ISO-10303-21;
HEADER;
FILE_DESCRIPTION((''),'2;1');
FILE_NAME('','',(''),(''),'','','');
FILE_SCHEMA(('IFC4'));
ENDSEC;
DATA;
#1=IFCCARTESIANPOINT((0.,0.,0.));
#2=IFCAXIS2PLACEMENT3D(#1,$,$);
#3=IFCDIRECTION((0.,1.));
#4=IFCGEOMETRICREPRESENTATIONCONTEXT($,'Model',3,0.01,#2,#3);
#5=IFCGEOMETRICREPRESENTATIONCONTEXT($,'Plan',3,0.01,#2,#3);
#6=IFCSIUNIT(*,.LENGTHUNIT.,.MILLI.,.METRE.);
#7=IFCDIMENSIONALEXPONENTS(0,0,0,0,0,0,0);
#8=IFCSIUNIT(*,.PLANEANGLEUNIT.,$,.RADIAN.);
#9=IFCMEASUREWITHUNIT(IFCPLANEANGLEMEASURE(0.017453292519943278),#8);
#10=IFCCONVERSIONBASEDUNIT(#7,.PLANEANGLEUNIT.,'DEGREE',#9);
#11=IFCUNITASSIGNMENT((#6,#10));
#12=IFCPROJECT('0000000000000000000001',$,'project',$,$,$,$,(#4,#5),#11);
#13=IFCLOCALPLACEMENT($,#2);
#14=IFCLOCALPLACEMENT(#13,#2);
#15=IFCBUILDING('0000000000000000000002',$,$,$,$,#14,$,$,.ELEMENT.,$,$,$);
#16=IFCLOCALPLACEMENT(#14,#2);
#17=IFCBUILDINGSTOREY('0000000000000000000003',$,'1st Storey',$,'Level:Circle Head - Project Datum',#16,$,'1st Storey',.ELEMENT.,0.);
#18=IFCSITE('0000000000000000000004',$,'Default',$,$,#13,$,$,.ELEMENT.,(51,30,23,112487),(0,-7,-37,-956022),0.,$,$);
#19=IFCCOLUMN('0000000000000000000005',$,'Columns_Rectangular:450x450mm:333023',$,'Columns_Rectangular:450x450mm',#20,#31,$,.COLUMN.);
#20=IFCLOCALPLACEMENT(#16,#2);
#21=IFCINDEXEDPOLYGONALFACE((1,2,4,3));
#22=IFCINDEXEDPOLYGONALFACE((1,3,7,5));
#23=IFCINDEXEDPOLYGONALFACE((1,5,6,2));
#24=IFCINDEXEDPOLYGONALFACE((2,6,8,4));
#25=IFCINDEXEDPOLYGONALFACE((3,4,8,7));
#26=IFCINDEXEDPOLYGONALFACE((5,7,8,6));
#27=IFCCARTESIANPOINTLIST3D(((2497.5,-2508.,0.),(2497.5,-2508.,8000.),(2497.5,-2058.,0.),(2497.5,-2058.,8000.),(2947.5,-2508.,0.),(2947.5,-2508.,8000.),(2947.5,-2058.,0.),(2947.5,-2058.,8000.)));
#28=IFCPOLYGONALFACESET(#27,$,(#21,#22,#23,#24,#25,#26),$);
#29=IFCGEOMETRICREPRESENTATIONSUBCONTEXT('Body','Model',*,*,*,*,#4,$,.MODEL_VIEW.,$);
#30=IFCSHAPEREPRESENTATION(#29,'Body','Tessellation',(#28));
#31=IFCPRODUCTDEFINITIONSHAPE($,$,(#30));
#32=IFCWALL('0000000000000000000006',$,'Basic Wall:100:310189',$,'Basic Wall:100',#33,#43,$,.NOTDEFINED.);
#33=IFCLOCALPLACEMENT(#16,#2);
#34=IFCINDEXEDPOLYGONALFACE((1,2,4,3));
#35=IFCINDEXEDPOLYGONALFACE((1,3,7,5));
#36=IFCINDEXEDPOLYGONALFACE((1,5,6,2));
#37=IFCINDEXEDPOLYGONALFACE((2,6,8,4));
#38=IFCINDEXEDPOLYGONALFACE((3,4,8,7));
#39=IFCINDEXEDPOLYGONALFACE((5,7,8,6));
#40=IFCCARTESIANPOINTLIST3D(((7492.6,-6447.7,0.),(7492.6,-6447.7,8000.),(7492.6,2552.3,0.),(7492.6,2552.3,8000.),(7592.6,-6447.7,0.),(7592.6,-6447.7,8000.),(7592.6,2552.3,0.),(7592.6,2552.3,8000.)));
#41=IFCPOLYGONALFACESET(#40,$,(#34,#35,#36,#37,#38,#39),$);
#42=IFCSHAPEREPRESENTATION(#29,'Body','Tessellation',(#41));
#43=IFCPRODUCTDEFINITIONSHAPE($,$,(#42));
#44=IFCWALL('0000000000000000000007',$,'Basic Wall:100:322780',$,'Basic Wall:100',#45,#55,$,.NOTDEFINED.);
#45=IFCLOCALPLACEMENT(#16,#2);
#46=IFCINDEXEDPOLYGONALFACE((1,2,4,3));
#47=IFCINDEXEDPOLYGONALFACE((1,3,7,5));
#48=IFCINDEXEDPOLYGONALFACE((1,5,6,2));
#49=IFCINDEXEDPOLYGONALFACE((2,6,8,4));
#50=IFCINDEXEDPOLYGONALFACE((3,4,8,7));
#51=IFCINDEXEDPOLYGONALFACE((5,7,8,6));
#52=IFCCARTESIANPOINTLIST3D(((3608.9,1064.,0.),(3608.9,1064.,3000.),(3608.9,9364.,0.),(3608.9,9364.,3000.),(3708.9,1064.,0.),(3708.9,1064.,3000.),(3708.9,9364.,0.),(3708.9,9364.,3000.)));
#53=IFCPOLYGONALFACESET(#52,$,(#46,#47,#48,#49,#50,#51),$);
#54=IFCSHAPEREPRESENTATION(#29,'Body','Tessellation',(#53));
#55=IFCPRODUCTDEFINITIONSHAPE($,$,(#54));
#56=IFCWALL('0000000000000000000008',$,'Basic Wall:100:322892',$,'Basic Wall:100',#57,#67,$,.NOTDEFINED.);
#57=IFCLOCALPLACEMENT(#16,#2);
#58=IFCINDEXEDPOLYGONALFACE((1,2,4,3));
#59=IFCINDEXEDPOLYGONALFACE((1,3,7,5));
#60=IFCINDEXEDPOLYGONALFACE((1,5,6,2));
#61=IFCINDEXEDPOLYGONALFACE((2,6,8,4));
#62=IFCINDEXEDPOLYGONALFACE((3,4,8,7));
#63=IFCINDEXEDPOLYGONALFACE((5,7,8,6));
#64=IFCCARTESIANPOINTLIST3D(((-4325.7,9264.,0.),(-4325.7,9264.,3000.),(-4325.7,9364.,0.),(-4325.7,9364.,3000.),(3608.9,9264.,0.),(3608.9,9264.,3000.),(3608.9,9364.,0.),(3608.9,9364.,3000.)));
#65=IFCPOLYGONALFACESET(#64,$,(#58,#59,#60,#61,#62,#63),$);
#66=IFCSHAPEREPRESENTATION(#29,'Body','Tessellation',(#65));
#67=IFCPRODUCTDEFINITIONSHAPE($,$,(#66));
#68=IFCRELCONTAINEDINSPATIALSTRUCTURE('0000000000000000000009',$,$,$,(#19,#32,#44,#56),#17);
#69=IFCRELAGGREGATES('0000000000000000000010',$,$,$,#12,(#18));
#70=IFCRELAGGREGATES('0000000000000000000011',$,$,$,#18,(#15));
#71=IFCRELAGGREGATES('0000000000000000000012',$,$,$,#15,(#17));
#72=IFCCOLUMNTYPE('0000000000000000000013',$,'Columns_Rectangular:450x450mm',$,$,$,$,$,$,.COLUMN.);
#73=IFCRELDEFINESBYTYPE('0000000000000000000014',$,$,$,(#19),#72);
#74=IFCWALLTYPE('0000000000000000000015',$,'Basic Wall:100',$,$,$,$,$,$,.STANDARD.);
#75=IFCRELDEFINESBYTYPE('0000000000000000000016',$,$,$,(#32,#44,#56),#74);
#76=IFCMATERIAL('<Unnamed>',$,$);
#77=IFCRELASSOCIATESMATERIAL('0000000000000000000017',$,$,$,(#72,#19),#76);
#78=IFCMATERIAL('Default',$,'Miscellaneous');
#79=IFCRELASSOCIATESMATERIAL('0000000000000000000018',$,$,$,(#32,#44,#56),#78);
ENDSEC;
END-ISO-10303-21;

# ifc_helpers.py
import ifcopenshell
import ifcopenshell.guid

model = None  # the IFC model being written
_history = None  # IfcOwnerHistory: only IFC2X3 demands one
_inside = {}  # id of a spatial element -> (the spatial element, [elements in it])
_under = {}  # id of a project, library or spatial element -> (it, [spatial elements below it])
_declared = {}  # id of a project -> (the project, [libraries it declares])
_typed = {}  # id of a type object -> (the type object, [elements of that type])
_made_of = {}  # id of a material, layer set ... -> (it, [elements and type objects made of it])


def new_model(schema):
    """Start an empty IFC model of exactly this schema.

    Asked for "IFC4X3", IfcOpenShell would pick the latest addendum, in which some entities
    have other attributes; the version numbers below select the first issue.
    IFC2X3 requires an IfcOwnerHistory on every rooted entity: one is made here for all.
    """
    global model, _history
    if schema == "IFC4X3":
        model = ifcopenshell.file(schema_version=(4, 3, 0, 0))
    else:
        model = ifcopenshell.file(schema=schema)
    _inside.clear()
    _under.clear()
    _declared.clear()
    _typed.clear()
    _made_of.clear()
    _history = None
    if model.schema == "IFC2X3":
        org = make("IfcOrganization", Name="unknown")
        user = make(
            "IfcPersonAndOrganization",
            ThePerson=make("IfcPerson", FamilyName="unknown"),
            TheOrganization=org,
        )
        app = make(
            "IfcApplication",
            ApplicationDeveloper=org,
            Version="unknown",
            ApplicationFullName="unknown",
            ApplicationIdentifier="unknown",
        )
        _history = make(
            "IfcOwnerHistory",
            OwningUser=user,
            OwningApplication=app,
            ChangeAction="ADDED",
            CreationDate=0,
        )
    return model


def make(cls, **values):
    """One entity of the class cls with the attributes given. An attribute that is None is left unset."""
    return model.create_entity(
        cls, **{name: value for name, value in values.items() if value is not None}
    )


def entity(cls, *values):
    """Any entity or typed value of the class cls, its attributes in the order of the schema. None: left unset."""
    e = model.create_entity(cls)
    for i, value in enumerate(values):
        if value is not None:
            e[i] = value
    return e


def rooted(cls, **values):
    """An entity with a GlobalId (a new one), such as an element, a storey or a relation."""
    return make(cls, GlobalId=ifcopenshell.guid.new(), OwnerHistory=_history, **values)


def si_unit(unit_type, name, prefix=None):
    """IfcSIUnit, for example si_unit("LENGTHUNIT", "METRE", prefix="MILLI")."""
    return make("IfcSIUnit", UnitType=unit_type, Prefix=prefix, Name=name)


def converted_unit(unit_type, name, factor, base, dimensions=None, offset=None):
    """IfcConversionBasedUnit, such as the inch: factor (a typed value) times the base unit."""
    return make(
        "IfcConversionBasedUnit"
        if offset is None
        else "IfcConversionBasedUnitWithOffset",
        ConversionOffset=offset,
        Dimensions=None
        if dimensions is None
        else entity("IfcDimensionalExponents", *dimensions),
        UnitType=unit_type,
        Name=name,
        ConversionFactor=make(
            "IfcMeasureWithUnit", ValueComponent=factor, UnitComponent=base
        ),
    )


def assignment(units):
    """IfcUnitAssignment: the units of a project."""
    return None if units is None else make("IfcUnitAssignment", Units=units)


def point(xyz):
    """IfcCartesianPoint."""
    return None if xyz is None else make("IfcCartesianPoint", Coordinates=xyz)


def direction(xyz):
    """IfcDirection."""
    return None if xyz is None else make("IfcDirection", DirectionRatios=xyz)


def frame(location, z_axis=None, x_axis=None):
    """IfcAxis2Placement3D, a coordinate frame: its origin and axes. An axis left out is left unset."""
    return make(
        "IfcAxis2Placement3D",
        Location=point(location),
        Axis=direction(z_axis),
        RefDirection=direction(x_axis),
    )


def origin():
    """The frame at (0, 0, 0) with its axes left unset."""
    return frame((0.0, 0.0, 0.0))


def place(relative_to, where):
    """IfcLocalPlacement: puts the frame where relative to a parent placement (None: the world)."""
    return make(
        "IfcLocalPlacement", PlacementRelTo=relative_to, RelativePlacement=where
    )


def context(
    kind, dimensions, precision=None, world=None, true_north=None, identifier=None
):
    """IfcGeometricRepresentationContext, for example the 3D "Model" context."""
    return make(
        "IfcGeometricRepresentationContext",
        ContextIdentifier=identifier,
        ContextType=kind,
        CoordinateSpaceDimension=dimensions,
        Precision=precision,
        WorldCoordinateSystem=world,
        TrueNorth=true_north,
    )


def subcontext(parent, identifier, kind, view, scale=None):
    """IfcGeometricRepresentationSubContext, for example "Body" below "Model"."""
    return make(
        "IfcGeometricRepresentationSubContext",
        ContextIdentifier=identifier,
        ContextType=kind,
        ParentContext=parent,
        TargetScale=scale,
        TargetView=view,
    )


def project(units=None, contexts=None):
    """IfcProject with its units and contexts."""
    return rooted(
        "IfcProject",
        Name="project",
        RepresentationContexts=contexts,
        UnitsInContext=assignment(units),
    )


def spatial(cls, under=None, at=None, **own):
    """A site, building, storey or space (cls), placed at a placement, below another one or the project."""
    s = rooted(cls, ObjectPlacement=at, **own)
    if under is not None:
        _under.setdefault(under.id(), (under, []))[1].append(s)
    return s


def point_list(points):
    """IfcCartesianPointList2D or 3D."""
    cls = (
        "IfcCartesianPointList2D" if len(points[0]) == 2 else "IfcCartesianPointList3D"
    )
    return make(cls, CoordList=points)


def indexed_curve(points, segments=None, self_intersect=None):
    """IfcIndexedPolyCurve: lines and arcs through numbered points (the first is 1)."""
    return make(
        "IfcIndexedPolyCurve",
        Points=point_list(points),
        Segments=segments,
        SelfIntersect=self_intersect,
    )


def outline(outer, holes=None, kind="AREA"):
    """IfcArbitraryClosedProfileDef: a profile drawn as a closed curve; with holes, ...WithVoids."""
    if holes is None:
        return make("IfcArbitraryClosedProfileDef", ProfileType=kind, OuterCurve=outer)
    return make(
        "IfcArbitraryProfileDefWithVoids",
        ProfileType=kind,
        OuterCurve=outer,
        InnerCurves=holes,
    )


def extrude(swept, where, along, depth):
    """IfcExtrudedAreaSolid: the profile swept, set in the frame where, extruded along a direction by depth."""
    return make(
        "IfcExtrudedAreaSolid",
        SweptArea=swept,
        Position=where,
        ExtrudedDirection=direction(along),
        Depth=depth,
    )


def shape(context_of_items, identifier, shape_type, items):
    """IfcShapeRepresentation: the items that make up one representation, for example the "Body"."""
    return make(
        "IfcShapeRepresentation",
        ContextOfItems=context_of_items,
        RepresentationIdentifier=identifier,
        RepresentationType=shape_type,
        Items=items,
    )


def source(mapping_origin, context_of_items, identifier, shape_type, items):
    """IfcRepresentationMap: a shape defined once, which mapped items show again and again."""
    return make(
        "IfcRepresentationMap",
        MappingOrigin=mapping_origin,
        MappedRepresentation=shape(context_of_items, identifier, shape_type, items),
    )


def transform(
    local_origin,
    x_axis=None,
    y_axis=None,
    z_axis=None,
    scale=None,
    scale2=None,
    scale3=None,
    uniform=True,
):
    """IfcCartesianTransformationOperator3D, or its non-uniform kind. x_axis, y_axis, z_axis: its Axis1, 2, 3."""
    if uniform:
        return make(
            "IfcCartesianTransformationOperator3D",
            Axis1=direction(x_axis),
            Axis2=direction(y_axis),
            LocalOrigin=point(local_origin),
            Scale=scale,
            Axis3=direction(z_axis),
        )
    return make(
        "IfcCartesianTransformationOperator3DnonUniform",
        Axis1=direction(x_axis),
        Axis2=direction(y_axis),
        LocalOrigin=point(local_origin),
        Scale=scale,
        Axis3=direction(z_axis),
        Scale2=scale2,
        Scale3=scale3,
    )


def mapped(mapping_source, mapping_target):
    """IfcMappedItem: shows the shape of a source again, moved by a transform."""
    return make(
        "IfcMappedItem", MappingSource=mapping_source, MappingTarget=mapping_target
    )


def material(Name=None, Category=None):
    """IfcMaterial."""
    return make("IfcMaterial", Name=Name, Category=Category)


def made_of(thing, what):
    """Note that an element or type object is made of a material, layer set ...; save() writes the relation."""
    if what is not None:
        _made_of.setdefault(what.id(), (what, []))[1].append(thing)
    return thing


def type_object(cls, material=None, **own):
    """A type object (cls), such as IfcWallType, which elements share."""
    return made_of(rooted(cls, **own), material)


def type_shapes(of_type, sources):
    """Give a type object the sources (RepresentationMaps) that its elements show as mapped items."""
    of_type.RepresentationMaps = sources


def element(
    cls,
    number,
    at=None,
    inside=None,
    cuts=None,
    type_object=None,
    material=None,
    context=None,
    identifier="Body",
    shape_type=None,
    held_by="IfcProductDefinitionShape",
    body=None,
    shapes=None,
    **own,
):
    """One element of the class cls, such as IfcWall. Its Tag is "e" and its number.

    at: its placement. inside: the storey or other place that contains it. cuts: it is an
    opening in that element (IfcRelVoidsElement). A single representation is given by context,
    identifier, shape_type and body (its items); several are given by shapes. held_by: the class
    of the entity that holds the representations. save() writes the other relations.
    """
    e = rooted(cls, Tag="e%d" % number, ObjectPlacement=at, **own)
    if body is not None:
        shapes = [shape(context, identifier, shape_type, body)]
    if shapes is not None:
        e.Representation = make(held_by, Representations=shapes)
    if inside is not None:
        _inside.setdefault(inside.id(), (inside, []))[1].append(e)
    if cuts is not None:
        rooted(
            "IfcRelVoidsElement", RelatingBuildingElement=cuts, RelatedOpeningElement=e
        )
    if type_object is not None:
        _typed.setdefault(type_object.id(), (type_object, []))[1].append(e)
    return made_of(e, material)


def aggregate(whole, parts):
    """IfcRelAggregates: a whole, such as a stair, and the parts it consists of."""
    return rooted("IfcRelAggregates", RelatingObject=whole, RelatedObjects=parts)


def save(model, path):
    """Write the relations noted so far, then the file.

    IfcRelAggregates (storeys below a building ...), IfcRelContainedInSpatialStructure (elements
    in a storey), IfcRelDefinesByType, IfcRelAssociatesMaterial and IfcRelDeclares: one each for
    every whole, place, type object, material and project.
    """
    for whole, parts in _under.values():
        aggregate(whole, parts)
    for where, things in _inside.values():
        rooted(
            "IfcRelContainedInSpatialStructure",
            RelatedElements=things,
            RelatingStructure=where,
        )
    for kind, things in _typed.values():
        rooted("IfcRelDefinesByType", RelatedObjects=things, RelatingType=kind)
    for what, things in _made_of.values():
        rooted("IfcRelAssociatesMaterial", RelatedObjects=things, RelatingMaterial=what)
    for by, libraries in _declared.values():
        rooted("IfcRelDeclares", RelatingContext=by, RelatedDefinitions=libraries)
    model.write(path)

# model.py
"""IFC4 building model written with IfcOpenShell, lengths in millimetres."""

from ifc_helpers import new_model, entity, si_unit, converted_unit, direction, frame, origin, place, context, subcontext, project, spatial, indexed_curve, outline, extrude, source, transform, mapped, material, type_object, type_shapes, element, save


model = new_model("IFC4")

# Units and contexts
model_context = context("Model", 3, precision=0.01, world=origin(), true_north=direction((0.0, 1.0)))
plan_context = context("Plan", 3, precision=0.01, world=origin(), true_north=direction((0.0, 1.0)))
body_context = subcontext(model_context, "Body", "Model", "MODEL_VIEW")
ifc_project = project(units=[si_unit("LENGTHUNIT", "METRE", prefix="MILLI"), converted_unit("PLANEANGLEUNIT", "DEGREE", entity("IfcPlaneAngleMeasure", 0.017453292519943278), si_unit("PLANEANGLEUNIT", "RADIAN"), dimensions=[0, 0, 0, 0, 0, 0, 0])], contexts=[model_context, plan_context])

# Site, building, storey
site_placement = place(None, origin())
site = spatial("IfcSite", under=ifc_project, at=site_placement, Name="Default", CompositionType="ELEMENT", RefLatitude=(51, 30, 23, 112487), RefLongitude=(0, -7, -37, -956022), RefElevation=0.0)
building_placement = place(site_placement, origin())
building = spatial("IfcBuilding", under=site, at=building_placement, CompositionType="ELEMENT")
storey_placement = place(building_placement, origin())
storey = spatial("IfcBuildingStorey", under=building, at=storey_placement, Name="1st Storey", ObjectType="Level:Circle Head - Project Datum", LongName="1st Storey", CompositionType="ELEMENT", Elevation=0.0)

# Column
ifc_material_1 = material(Name="<Unnamed>")
column_type = type_object("IfcColumnType", Name="Columns_Rectangular:450x450mm", PredefinedType="COLUMN", material=ifc_material_1)
shared_shape = source(origin(), body_context, "Body", "SweptSolid", [
    extrude(outline(indexed_curve([(-225.0, -225.0), (225.0, -225.0), (225.0, 225.0), (-225.0, 225.0), (-225.0, -225.0)], self_intersect=False)), frame((0.0, 0.0, 0.0), z_axis=(0.0, 0.0, 1.0), x_axis=(-1.0, 0.0, 0.0)), (0.0, 0.0, 1.0), 8000.0),
])
type_shapes(column_type, [shared_shape])
column_placement = place(storey_placement, frame((2722.5, -2283.0, 0.0)))
element("IfcColumn", 1, at=column_placement, inside=storey, type_object=column_type, material=ifc_material_1, Name="Columns_Rectangular:450x450mm:333023", ObjectType="Columns_Rectangular:450x450mm", PredefinedType="COLUMN", context=body_context, shape_type="MappedRepresentation", body=[
    mapped(shared_shape, transform((0.0, 0.0, 0.0), scale=1.0)),
])

# Walls
ifc_material_2 = material(Name="Default", Category="Miscellaneous")
wall_type = type_object("IfcWallType", Name="Basic Wall:100", PredefinedType="STANDARD")
wall_1_placement = place(storey_placement, frame((7542.6, 2552.3, 0.0), z_axis=(0.0, 0.0, 1.0), x_axis=(0.0, -1.0, 0.0)))
element("IfcWall", 2, at=wall_1_placement, inside=storey, type_object=wall_type, material=ifc_material_2, Name="Basic Wall:100:310189", ObjectType="Basic Wall:100", PredefinedType="NOTDEFINED", context=body_context, shape_type="SweptSolid", body=[
    extrude(outline(indexed_curve([(9000.0, 50.0), (0.0, 50.0), (0.0, -50.0), (9000.0, -50.0), (9000.0, 50.0)], self_intersect=False)), origin(), (0.0, 0.0, 1.0), 8000.0),
])
wall_2_placement = place(storey_placement, frame((3658.9, 1064.0, 0.0), z_axis=(0.0, 0.0, 1.0), x_axis=(0.0, 1.0, 0.0)))
element("IfcWall", 3, at=wall_2_placement, inside=storey, type_object=wall_type, material=ifc_material_2, Name="Basic Wall:100:322780", ObjectType="Basic Wall:100", PredefinedType="NOTDEFINED", context=body_context, shape_type="SweptSolid", body=[
    extrude(outline(indexed_curve([(8300.0, 50.0), (0.0, 50.0), (0.0, -50.0), (8300.0, -50.0), (8300.0, 50.0)], self_intersect=False)), origin(), (0.0, 0.0, 1.0), 3000.0),
])
wall_3_placement = place(storey_placement, frame((3608.9, 9314.0, 0.0), z_axis=(0.0, 0.0, 1.0), x_axis=(-1.0, 0.0, 0.0)))
element("IfcWall", 4, at=wall_3_placement, inside=storey, type_object=wall_type, material=ifc_material_2, Name="Basic Wall:100:322892", ObjectType="Basic Wall:100", PredefinedType="NOTDEFINED", context=body_context, shape_type="SweptSolid", body=[
    extrude(outline(indexed_curve([(7934.6, 50.0), (0.0, 50.0), (0.0, -50.0), (7934.6, -50.0), (7934.6, 50.0)], self_intersect=False)), origin(), (0.0, 0.0, 1.0), 3000.0),
])

save(model, "model.ifc")
